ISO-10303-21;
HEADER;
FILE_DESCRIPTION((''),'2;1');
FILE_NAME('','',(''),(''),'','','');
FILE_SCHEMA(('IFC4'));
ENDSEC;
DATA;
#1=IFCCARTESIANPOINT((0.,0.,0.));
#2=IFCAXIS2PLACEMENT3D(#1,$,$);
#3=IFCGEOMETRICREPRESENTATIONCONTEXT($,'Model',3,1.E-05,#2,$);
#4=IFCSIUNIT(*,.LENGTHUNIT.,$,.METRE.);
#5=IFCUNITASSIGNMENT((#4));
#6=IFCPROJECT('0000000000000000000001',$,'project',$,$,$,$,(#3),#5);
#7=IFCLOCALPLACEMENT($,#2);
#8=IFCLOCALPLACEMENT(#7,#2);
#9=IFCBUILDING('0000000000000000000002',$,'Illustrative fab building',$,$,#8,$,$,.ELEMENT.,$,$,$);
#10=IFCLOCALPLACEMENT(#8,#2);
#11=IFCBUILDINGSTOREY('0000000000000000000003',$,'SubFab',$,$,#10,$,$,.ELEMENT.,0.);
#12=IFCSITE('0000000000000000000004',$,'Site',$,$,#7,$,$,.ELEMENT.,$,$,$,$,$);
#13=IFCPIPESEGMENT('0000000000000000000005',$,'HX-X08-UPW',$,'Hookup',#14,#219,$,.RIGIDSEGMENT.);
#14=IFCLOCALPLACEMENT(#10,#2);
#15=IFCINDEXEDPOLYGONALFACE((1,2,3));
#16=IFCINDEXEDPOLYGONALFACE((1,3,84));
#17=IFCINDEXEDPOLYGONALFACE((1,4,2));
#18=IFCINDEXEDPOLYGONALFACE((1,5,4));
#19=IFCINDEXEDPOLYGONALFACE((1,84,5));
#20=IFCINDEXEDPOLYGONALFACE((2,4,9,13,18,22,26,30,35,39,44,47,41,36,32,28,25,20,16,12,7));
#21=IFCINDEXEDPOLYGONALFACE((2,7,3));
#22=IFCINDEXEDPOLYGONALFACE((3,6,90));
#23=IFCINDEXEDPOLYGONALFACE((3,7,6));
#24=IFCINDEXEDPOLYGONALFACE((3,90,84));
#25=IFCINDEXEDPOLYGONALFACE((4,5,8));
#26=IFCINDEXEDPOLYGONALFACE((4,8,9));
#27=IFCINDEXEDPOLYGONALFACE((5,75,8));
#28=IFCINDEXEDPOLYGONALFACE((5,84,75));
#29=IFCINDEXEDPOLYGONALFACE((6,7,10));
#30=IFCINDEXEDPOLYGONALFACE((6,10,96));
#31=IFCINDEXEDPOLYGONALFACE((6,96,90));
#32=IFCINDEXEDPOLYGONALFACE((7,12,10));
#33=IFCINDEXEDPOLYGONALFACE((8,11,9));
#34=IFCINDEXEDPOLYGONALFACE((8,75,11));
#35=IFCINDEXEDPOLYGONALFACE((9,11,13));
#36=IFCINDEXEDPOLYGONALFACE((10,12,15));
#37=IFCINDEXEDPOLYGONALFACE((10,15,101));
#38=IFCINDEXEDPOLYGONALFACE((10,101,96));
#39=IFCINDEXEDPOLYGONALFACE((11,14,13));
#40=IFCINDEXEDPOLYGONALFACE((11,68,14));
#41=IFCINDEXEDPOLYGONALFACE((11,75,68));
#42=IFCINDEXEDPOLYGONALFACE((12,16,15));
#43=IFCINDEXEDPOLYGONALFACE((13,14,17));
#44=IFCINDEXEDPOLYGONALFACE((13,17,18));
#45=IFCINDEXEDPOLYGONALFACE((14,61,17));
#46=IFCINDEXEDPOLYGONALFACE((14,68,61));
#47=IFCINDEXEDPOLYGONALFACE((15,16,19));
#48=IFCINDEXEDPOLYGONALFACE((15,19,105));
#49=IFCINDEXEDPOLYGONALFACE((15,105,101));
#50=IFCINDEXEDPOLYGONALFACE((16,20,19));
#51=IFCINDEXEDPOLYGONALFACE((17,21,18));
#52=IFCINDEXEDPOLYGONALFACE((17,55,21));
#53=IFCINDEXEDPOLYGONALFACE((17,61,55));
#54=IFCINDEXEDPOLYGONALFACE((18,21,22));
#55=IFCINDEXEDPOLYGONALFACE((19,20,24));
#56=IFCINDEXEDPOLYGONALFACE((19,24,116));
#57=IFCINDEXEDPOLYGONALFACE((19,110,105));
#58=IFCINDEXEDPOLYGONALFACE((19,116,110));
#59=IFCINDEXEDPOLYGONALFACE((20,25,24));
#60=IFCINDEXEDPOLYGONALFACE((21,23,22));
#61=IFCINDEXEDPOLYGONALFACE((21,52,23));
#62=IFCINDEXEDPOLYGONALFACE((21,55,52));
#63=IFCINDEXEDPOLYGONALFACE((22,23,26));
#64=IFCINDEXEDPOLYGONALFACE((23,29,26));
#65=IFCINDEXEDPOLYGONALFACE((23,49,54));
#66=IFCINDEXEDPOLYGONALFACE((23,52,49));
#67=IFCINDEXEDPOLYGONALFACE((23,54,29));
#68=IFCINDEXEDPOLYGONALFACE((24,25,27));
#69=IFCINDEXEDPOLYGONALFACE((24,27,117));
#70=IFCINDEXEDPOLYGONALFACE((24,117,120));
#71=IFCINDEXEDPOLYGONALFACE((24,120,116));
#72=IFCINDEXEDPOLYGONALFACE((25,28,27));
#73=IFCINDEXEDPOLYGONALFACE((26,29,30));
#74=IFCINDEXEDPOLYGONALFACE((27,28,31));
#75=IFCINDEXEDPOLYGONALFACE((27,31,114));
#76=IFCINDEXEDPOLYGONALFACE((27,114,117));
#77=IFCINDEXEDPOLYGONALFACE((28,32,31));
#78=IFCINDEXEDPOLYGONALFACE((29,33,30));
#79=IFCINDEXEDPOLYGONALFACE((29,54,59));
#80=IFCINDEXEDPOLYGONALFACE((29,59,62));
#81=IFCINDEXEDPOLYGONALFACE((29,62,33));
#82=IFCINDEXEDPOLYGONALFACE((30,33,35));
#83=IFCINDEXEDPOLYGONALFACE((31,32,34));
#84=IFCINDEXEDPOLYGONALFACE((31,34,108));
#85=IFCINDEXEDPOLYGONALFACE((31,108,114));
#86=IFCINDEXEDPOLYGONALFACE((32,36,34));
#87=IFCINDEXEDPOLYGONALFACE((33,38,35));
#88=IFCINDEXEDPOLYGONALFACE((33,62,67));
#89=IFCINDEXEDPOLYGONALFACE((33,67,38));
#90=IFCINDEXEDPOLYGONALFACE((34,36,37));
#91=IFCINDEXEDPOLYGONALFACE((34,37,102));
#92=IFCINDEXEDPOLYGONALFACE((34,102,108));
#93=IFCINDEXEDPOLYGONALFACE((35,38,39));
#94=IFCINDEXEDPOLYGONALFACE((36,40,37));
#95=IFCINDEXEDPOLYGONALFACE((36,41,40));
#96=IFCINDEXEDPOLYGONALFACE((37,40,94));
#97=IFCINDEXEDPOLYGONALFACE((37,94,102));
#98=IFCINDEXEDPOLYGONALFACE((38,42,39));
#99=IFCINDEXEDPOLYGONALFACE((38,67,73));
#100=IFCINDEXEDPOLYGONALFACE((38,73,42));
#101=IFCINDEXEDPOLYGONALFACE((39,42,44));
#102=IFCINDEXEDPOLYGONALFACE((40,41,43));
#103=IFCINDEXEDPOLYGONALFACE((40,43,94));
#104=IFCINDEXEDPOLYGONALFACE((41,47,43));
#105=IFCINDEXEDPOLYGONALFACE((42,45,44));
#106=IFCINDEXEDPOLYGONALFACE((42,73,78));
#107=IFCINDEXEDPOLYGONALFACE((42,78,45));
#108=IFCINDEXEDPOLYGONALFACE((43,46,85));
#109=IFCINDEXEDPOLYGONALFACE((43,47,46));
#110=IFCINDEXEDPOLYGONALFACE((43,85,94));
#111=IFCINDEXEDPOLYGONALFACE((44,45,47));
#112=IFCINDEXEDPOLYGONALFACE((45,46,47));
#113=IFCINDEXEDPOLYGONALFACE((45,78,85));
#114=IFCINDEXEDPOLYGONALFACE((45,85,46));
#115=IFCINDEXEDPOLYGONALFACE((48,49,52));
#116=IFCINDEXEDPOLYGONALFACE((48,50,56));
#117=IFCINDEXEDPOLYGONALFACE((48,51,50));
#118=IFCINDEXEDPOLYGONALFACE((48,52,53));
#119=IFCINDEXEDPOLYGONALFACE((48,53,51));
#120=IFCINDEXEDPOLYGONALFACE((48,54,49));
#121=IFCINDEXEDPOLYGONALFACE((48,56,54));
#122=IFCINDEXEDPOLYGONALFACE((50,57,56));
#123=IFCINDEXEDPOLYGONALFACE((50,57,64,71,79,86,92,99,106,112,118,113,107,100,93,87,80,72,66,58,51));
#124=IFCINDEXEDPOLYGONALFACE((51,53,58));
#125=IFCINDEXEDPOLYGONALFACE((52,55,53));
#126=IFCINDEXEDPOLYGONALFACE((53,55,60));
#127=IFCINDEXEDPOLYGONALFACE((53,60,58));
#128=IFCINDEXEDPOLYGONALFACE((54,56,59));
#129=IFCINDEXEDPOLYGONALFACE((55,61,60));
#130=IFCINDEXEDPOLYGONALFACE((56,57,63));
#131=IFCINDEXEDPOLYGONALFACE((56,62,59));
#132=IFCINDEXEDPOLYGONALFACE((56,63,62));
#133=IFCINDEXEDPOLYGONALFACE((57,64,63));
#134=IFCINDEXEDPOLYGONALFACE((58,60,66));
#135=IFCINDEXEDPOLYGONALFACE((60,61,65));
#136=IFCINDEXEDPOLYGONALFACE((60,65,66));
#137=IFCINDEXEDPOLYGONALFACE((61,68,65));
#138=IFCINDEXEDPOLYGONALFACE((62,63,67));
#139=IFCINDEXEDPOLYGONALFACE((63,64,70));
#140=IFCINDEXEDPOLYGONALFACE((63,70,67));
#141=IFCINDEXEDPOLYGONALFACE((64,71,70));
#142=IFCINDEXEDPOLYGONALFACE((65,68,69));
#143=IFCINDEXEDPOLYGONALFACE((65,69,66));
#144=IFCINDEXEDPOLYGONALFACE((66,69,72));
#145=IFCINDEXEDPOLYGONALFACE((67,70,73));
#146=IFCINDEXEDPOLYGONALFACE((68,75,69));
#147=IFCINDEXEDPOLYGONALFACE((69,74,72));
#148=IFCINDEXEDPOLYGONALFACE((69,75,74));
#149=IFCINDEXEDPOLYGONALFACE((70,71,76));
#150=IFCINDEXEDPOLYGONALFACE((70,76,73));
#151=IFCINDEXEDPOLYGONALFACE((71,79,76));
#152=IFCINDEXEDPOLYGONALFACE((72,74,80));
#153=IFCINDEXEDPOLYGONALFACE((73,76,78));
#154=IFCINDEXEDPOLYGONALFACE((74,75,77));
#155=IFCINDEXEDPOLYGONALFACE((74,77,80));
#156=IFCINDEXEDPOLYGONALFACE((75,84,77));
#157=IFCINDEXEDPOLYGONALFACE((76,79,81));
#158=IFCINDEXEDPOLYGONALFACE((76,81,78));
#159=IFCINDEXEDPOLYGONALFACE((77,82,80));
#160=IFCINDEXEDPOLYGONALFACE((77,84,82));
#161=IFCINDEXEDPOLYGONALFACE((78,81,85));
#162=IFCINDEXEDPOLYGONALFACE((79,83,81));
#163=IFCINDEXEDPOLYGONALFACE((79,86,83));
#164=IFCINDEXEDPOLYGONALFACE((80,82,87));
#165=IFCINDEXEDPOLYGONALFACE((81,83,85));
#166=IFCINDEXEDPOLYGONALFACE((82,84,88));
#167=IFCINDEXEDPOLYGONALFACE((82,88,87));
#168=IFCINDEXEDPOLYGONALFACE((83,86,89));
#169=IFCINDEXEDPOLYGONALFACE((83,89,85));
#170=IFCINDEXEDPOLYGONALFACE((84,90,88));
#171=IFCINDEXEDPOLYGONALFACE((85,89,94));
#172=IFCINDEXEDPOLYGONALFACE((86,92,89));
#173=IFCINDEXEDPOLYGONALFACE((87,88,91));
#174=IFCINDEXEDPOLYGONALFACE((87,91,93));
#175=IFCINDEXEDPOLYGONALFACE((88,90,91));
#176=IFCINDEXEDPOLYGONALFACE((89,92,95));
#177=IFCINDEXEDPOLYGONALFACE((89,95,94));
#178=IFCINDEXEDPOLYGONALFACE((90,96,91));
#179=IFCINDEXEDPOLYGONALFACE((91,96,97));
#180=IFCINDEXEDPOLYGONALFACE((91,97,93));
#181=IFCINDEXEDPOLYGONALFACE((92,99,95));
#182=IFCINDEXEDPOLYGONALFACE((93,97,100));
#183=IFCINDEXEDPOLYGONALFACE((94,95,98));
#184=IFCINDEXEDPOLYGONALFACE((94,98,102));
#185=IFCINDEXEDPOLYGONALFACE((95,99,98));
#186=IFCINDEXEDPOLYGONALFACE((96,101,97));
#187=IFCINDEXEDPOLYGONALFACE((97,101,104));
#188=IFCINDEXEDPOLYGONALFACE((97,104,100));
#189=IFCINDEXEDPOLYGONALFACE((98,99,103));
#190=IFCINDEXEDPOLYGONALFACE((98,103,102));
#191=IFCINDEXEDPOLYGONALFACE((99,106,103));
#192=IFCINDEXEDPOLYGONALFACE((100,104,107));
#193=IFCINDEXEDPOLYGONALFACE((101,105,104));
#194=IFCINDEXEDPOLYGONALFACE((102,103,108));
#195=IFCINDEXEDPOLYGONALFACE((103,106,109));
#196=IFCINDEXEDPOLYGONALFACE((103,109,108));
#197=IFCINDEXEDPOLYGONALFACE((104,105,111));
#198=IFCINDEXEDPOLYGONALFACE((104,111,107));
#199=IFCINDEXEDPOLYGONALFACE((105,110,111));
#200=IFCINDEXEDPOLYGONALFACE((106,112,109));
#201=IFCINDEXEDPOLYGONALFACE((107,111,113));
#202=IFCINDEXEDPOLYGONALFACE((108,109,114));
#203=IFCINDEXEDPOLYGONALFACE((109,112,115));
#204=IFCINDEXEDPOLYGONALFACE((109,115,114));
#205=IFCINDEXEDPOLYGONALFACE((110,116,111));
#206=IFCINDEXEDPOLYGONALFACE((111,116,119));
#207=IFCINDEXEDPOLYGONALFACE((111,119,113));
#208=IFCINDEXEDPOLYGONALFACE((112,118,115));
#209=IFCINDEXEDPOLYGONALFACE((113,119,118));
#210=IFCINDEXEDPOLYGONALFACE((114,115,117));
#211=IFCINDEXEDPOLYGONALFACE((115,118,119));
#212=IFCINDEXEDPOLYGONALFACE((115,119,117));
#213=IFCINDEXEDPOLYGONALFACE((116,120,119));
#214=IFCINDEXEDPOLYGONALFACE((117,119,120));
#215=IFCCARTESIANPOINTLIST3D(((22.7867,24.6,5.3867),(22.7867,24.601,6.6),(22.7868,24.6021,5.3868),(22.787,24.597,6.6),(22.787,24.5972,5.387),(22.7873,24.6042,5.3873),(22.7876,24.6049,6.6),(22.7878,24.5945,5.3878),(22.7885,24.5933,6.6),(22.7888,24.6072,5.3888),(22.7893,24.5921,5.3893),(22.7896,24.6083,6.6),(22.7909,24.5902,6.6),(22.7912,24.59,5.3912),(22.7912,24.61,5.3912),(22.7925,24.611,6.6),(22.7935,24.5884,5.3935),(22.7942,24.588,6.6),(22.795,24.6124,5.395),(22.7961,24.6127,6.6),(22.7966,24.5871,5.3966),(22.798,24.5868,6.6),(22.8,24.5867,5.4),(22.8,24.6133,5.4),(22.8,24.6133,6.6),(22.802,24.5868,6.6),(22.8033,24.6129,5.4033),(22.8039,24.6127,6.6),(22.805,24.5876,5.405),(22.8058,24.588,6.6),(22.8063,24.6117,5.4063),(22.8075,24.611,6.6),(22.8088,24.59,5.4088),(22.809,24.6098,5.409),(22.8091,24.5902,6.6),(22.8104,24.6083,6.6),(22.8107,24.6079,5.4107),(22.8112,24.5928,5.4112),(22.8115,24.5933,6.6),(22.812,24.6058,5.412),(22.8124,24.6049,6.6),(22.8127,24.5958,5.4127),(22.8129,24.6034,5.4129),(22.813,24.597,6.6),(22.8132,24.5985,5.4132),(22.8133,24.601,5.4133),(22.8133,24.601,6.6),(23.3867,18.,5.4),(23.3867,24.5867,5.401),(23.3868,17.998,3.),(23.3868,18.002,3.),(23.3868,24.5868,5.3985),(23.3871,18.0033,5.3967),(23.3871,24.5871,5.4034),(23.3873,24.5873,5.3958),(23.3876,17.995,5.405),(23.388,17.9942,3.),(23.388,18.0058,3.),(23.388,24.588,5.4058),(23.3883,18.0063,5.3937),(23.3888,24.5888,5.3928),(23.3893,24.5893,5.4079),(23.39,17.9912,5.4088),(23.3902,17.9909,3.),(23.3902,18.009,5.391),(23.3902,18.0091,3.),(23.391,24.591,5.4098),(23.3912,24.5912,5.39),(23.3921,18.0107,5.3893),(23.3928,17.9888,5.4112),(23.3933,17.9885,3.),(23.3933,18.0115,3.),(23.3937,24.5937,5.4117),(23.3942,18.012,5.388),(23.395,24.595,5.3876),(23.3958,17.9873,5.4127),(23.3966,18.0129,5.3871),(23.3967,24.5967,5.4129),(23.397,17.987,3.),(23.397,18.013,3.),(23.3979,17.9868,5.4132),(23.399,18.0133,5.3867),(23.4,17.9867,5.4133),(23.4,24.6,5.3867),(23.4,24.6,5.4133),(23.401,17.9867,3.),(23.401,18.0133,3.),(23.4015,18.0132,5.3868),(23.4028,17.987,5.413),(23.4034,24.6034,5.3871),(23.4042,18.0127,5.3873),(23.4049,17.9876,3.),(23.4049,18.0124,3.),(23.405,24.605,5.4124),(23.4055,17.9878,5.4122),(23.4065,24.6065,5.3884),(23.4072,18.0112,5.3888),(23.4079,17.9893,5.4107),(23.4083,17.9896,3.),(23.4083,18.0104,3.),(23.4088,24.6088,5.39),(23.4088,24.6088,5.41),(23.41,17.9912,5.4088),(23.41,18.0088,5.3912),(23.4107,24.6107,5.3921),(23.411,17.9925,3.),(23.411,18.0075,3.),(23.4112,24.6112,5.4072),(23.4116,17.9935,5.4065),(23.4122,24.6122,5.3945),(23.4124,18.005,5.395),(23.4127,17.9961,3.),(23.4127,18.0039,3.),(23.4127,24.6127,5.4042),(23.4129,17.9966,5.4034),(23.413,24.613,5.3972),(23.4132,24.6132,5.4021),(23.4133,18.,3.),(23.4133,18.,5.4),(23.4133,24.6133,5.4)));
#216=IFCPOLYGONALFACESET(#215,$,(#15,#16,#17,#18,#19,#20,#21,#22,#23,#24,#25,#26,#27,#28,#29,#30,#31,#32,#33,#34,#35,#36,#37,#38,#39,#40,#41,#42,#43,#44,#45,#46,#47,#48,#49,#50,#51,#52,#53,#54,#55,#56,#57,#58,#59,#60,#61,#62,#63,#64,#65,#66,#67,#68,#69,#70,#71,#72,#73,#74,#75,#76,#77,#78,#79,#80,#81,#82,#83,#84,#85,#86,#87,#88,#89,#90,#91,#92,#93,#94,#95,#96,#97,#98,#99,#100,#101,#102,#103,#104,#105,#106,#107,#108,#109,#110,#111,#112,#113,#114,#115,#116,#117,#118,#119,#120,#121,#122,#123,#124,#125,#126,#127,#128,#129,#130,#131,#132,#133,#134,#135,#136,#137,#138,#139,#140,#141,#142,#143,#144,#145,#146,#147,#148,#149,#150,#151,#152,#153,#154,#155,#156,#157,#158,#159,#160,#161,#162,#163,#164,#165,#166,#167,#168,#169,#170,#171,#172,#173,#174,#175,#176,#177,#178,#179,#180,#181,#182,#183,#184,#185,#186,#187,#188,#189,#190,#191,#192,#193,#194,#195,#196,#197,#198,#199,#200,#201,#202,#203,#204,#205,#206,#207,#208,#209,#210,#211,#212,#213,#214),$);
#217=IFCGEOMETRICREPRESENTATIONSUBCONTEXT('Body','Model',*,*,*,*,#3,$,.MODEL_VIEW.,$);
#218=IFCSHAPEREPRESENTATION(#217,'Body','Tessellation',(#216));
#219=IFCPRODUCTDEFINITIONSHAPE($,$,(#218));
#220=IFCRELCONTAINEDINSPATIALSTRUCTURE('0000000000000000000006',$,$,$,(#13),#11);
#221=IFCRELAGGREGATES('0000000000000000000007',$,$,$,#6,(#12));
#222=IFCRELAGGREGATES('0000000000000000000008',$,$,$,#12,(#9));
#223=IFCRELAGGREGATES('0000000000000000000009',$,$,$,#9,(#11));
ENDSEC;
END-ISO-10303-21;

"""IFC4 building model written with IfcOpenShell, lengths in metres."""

from ifc_helpers import new_model, entity, si_unit, origin, place, context, subcontext, project, spatial, element, save


model = new_model("IFC4")

# Units and contexts
model_context = context("Model", 3, precision=1e-05, world=origin())
body_context = subcontext(model_context, "Body", "Model", "MODEL_VIEW")
ifc_project = project(units=[si_unit("LENGTHUNIT", "METRE")], contexts=[model_context])

# Site, building, storey
site_placement = place(None, origin())
site = spatial("IfcSite", under=ifc_project, at=site_placement, Name="Site", CompositionType="ELEMENT")
building_placement = place(site_placement, origin())
building = spatial("IfcBuilding", under=site, at=building_placement, Name="Illustrative fab building", CompositionType="ELEMENT")
storey_placement = place(building_placement, origin())
storey = spatial("IfcBuildingStorey", under=building, at=storey_placement, Name="SubFab", CompositionType="ELEMENT", Elevation=0.0)

# Pipe segment
pipe_segment_1_placement = place(storey_placement, origin())
element("IfcPipeSegment", 1, at=pipe_segment_1_placement, inside=storey, Name="HX-X08-UPW", ObjectType="Hookup", PredefinedType="RIGIDSEGMENT", context=body_context, shape_type="AdvancedSweptSolid", body=[
    entity("IfcSweptDiskSolid", entity("IfcPolyline", [entity("IfcCartesianPoint", [23.4, 18.0, 3.0]), entity("IfcCartesianPoint", [23.4, 18.0, 5.4]), entity("IfcCartesianPoint", [23.4, 24.6, 5.4]), entity("IfcCartesianPoint", [22.8, 24.6, 5.4]), entity("IfcCartesianPoint", [22.8, 24.6, 6.6])]), 0.0133),
])

save(model, "model.ifc")
